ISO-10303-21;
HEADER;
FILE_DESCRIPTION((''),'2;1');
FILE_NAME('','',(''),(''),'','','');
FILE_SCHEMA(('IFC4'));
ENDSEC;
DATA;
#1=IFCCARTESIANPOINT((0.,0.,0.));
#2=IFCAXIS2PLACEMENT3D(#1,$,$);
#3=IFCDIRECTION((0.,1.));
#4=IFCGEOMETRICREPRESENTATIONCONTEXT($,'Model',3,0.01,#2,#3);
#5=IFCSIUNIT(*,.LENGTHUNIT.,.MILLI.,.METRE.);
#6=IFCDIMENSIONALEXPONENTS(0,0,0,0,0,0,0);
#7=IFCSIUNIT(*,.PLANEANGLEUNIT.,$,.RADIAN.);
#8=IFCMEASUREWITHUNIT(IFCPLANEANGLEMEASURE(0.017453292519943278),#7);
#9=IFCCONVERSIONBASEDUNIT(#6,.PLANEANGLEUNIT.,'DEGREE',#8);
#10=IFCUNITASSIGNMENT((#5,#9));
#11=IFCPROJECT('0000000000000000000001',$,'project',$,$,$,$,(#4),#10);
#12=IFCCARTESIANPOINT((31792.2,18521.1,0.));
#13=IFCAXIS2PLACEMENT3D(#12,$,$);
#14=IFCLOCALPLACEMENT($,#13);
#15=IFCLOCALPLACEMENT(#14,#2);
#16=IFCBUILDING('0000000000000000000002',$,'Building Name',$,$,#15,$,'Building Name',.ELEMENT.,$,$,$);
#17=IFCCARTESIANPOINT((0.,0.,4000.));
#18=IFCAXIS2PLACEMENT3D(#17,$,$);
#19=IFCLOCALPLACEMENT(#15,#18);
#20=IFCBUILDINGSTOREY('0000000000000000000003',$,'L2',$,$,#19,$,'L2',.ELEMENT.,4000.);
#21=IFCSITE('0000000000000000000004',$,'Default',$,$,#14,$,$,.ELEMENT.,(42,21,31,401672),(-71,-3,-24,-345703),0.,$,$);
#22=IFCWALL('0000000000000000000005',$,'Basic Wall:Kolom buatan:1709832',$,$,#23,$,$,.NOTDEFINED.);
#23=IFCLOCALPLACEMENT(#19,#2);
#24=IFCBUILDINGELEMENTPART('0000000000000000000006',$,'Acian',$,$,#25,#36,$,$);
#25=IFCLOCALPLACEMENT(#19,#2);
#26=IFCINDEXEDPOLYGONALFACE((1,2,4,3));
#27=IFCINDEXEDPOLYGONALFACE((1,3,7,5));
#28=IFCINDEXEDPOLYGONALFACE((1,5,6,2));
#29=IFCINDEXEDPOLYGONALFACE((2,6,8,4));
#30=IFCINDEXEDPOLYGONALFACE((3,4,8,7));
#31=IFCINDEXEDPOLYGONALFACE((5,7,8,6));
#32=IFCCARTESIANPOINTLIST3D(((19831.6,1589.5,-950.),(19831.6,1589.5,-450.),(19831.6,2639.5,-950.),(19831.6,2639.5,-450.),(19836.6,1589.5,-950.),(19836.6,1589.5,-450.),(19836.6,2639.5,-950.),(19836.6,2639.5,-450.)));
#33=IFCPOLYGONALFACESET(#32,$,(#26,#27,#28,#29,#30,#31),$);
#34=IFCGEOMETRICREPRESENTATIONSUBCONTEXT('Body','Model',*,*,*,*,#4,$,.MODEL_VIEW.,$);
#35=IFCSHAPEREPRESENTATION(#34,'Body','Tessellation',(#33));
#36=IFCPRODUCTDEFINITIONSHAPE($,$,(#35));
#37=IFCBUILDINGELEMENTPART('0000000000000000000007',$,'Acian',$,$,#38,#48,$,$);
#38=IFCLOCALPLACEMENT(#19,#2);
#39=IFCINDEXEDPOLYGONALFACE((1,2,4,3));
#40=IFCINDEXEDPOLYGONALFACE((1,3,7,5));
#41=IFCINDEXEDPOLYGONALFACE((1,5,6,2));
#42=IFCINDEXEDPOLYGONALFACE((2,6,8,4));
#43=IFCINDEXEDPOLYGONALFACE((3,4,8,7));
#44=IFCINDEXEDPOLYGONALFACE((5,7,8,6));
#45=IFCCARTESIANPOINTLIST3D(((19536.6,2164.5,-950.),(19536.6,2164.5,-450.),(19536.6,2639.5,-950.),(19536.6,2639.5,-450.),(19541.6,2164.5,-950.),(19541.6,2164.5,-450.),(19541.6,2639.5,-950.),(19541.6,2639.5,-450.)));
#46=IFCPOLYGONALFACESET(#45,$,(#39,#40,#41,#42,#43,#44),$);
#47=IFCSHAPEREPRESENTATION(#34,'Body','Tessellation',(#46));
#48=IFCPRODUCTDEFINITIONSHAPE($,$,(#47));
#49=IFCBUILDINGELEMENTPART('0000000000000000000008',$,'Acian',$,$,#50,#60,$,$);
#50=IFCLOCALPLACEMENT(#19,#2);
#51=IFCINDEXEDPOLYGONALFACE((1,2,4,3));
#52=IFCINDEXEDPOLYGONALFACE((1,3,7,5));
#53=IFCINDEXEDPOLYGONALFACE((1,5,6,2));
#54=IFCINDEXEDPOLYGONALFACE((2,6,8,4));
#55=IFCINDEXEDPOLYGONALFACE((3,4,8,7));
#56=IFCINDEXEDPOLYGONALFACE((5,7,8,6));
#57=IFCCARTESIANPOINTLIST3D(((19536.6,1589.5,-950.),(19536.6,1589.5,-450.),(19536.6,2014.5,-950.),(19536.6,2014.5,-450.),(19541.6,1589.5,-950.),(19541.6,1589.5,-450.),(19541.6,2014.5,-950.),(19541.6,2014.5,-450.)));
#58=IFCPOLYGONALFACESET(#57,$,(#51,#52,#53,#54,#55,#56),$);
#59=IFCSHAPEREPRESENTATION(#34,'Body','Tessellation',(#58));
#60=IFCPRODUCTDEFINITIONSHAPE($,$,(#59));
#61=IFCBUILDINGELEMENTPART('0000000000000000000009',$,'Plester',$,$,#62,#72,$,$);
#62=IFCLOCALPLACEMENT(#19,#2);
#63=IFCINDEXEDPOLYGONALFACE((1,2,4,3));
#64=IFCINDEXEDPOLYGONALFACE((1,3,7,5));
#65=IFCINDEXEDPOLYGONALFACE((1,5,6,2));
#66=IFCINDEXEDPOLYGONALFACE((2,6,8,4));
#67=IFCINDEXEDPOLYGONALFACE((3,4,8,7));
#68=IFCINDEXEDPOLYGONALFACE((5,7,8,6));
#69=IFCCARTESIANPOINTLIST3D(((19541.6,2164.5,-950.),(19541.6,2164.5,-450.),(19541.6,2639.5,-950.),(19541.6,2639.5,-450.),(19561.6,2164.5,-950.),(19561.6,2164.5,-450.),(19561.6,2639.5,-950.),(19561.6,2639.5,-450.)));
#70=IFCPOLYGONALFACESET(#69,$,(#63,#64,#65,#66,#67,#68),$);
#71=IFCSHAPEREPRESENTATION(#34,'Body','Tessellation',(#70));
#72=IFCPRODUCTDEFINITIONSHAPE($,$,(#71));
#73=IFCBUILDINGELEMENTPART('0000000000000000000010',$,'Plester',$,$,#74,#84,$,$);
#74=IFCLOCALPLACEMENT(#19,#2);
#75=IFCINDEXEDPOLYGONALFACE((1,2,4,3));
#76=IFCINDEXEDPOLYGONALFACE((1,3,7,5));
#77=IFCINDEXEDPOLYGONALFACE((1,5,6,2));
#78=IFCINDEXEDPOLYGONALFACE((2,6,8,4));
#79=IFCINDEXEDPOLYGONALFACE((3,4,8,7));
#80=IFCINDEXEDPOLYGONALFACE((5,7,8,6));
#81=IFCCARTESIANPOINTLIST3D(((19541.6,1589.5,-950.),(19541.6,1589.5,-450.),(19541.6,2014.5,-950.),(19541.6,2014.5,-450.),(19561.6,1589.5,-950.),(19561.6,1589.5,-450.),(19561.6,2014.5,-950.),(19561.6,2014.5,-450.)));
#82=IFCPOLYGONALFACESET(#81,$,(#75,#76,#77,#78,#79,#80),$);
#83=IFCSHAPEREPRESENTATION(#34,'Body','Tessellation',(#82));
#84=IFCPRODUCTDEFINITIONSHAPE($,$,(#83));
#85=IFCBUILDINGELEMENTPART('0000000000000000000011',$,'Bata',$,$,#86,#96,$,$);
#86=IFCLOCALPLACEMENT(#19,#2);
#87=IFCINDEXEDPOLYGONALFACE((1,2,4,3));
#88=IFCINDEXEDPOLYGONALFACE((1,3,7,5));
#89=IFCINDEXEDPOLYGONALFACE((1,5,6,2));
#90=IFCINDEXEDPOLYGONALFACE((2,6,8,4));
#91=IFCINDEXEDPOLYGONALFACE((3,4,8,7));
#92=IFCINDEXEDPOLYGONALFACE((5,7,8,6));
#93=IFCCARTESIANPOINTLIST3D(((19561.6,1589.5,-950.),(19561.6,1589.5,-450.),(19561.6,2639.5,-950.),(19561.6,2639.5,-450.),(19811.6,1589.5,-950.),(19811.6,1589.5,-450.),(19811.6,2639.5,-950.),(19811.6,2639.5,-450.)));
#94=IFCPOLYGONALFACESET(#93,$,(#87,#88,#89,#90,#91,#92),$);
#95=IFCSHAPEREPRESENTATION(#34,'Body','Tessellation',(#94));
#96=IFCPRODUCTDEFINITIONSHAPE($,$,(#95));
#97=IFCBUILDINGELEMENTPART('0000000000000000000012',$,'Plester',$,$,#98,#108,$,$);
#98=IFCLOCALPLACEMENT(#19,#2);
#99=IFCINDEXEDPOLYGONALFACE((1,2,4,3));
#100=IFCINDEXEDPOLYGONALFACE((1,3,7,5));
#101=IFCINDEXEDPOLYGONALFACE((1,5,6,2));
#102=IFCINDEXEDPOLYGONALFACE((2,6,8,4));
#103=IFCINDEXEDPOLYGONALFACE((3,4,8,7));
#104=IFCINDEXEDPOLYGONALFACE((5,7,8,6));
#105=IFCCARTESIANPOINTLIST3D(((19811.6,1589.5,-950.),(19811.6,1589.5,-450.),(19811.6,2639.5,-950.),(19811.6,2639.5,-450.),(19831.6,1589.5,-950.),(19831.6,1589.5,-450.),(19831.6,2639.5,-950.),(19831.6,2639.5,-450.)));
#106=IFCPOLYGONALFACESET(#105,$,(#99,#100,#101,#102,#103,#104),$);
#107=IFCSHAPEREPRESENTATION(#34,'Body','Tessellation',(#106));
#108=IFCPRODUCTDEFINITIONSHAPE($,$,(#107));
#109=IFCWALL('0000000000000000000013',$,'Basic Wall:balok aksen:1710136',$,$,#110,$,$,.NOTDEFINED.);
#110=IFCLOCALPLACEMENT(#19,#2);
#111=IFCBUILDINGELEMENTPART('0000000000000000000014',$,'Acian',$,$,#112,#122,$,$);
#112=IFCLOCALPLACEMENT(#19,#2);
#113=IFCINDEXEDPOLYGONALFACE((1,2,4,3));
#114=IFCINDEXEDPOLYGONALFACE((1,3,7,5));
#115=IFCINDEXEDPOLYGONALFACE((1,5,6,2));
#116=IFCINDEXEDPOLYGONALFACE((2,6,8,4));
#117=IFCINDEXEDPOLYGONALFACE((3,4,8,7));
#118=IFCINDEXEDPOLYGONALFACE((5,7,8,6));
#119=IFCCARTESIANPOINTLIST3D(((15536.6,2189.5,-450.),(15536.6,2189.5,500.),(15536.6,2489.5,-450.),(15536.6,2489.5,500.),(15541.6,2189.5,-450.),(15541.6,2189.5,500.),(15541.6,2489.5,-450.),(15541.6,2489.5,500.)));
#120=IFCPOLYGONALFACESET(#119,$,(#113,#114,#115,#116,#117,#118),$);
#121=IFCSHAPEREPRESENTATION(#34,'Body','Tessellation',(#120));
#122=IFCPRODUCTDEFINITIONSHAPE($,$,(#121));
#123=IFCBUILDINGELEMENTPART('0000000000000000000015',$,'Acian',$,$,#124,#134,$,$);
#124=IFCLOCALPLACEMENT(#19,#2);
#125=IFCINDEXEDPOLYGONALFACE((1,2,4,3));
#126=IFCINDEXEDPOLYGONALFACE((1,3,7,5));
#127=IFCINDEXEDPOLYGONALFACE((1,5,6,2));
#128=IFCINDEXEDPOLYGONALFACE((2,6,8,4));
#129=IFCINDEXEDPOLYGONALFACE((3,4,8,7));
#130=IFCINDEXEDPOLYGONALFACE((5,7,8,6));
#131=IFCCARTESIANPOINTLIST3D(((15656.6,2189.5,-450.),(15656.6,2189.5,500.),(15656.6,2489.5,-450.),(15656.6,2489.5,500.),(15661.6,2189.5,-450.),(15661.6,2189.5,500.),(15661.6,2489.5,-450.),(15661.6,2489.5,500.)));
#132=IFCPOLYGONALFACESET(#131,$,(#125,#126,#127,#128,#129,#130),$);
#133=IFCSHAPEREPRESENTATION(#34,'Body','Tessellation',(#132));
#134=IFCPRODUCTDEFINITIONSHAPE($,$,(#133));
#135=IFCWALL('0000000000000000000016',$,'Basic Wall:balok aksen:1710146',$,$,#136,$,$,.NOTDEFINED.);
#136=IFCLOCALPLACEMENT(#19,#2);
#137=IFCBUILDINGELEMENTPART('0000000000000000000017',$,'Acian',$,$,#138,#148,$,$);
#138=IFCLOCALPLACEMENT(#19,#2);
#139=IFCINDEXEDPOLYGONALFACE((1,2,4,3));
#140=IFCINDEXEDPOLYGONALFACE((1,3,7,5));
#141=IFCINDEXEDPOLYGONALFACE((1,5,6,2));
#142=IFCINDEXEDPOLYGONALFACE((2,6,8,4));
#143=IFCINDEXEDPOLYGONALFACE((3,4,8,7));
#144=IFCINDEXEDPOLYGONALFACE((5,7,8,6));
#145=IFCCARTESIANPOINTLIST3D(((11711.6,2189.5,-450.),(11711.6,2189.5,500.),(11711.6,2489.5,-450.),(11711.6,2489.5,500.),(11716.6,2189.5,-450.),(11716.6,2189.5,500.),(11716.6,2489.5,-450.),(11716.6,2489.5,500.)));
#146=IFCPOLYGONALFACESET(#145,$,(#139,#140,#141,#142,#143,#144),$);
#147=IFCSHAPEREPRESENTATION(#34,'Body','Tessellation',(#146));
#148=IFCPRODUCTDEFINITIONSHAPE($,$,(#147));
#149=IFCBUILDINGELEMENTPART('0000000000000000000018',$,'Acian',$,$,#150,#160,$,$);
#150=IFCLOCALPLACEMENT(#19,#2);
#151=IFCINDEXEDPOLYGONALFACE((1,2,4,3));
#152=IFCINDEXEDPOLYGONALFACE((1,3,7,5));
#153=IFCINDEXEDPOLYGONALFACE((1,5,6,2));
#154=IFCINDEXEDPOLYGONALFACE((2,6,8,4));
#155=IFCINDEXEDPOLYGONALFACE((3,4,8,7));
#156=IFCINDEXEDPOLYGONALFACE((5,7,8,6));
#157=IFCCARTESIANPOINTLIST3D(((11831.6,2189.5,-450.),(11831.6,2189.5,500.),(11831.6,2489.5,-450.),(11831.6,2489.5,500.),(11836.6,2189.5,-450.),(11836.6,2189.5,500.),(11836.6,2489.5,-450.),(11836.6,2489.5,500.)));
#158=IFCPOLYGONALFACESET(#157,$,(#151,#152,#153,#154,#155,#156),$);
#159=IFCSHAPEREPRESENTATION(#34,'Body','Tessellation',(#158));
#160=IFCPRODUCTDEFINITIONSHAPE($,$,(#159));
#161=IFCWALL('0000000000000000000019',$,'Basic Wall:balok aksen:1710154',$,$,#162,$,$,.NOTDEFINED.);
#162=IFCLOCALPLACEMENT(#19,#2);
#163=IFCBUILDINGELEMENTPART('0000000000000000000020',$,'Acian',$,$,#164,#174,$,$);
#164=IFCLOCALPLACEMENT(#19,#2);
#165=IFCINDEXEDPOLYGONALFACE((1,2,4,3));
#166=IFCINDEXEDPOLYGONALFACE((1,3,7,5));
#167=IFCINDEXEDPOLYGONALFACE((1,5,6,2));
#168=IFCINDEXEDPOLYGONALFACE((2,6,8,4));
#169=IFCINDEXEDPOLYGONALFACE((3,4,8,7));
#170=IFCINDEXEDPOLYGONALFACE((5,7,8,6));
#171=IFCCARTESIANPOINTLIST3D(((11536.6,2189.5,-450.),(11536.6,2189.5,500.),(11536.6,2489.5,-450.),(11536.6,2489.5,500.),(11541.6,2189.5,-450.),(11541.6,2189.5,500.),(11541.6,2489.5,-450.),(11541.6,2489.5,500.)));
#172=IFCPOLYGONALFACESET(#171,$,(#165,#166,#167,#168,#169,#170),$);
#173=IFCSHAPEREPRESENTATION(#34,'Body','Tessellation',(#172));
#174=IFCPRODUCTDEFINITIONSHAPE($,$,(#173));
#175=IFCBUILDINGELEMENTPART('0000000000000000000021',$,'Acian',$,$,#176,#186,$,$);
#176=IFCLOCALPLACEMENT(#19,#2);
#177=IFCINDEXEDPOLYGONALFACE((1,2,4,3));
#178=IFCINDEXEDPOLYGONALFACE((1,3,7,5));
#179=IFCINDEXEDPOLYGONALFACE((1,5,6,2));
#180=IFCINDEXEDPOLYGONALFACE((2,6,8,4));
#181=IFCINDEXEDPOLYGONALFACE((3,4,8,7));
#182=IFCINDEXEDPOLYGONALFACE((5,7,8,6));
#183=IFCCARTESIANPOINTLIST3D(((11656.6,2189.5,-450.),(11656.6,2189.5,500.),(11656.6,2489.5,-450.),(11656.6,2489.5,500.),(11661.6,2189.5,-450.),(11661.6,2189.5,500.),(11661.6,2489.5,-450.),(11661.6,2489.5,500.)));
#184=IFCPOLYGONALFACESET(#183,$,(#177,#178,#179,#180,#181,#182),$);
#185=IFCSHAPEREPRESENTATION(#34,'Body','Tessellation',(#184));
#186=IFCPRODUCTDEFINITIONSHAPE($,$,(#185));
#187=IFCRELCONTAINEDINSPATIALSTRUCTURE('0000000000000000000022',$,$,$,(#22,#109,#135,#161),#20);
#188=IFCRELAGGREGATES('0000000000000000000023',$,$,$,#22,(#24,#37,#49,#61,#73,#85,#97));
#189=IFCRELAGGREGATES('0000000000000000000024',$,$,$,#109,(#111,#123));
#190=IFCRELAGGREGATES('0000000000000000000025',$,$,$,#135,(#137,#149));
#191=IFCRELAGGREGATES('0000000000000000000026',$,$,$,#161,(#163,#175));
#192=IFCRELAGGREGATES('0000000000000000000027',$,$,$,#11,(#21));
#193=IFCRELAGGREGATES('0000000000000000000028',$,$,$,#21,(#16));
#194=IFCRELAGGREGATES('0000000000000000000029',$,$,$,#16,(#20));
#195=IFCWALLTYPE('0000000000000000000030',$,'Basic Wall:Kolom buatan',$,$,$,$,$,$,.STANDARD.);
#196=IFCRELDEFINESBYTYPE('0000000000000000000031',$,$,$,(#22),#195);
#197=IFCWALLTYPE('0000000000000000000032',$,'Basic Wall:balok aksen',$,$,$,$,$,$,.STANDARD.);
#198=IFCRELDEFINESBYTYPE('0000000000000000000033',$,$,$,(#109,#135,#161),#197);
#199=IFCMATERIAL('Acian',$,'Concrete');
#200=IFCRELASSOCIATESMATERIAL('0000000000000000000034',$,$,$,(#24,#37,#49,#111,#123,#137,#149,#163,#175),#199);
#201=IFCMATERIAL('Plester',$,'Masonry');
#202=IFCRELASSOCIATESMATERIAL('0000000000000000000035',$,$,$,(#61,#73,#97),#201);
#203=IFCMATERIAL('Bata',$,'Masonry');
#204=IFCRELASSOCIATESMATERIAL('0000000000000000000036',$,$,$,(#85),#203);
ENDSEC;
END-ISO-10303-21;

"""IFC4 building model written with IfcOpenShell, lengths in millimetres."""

from ifc_helpers import new_model, entity, si_unit, converted_unit, direction, frame, origin, place, context, subcontext, project, spatial, indexed_curve, outline, extrude, material, type_object, element, aggregate, save


model = new_model("IFC4")

# Units and contexts
model_context = context("Model", 3, precision=0.01, world=origin(), true_north=direction((0.0, 1.0)))
body_context = subcontext(model_context, "Body", "Model", "MODEL_VIEW")
ifc_project = project(units=[si_unit("LENGTHUNIT", "METRE", prefix="MILLI"), converted_unit("PLANEANGLEUNIT", "DEGREE", entity("IfcPlaneAngleMeasure", 0.017453292519943278), si_unit("PLANEANGLEUNIT", "RADIAN"), dimensions=[0, 0, 0, 0, 0, 0, 0])], contexts=[model_context])

# Site, building, storey
site_placement = place(None, frame((31792.2, 18521.1, 0.0)))
site = spatial("IfcSite", under=ifc_project, at=site_placement, Name="Default", CompositionType="ELEMENT", RefLatitude=(42, 21, 31, 401672), RefLongitude=(-71, -3, -24, -345703), RefElevation=0.0)
building_placement = place(site_placement, origin())
building = spatial("IfcBuilding", under=site, at=building_placement, Name="Building Name", LongName="Building Name", CompositionType="ELEMENT")
storey_placement = place(building_placement, frame((0.0, 0.0, 4000.0)))
storey = spatial("IfcBuildingStorey", under=building, at=storey_placement, Name="L2", LongName="L2", CompositionType="ELEMENT", Elevation=4000.0)

# Shared definitions
ifc_material_1 = material(Name="Acian", Category="Concrete")
ifc_material_2 = material(Name="Plester", Category="Masonry")
ifc_material_3 = material(Name="Bata", Category="Masonry")

# Walls, building element parts
wall_type_1 = type_object("IfcWallType", Name="Basic Wall:Kolom buatan", PredefinedType="STANDARD")
wall_1_placement = place(storey_placement, frame((19686.6, 1589.5, -950.0), z_axis=(0.0, 0.0, 1.0), x_axis=(0.0, 1.0, 0.0)))
wall_1 = element("IfcWall", 1, at=wall_1_placement, inside=storey, type_object=wall_type_1, Name="Basic Wall:Kolom buatan:1709832", PredefinedType="NOTDEFINED")
building_element_part_1_placement = place(wall_1_placement, origin())
building_element_part_1 = element("IfcBuildingElementPart", 2, at=building_element_part_1_placement, material=ifc_material_1, Name="Acian", context=body_context, shape_type="SweptSolid", body=[
    extrude(outline(indexed_curve([(-525.0, -2.5), (525.0, -2.5), (525.0, 2.5), (-525.0, 2.5), (-525.0, -2.5)], self_intersect=False)), frame((525.0, -147.5, 0.0), z_axis=(0.0, 0.0, 1.0), x_axis=(-1.0, 0.0, 0.0)), (0.0, 0.0, 1.0), 500.0),
])
building_element_part_2_placement = place(wall_1_placement, origin())
building_element_part_2 = element("IfcBuildingElementPart", 3, at=building_element_part_2_placement, material=ifc_material_1, Name="Acian", context=body_context, shape_type="SweptSolid", body=[
    extrude(outline(indexed_curve([(-237.5, -2.5), (237.5, -2.5), (237.5, 2.5), (-237.5, 2.5), (-237.5, -2.5)], self_intersect=False)), frame((812.5, 147.5, 0.0), z_axis=(0.0, 0.0, 1.0), x_axis=(-1.0, 0.0, 0.0)), (0.0, 0.0, 1.0), 500.0),
])
building_element_part_3_placement = place(wall_1_placement, origin())
building_element_part_3 = element("IfcBuildingElementPart", 4, at=building_element_part_3_placement, material=ifc_material_1, Name="Acian", context=body_context, shape_type="SweptSolid", body=[
    extrude(outline(indexed_curve([(-212.5, -2.5), (212.5, -2.5), (212.5, 2.5), (-212.5, 2.5), (-212.5, -2.5)], self_intersect=False)), frame((212.5, 147.5, 0.0), z_axis=(0.0, 0.0, 1.0), x_axis=(-1.0, 0.0, 0.0)), (0.0, 0.0, 1.0), 500.0),
])
building_element_part_4_placement = place(wall_1_placement, origin())
building_element_part_4 = element("IfcBuildingElementPart", 5, at=building_element_part_4_placement, material=ifc_material_2, Name="Plester", context=body_context, shape_type="SweptSolid", body=[
    extrude(outline(indexed_curve([(-237.5, -10.0), (237.5, -10.0), (237.5, 10.0), (-237.5, 10.0), (-237.5, -10.0)], self_intersect=False)), frame((812.5, 135.0, 0.0), z_axis=(0.0, 0.0, 1.0), x_axis=(-1.0, 0.0, 0.0)), (0.0, 0.0, 1.0), 500.0),
])
building_element_part_5_placement = place(wall_1_placement, origin())
building_element_part_5 = element("IfcBuildingElementPart", 6, at=building_element_part_5_placement, material=ifc_material_2, Name="Plester", context=body_context, shape_type="SweptSolid", body=[
    extrude(outline(indexed_curve([(-212.5, -10.0), (212.5, -10.0), (212.5, 10.0), (-212.5, 10.0), (-212.5, -10.0)], self_intersect=False)), frame((212.5, 135.0, 0.0), z_axis=(0.0, 0.0, 1.0), x_axis=(-1.0, 0.0, 0.0)), (0.0, 0.0, 1.0), 500.0),
])
building_element_part_6_placement = place(wall_1_placement, origin())
building_element_part_6 = element("IfcBuildingElementPart", 7, at=building_element_part_6_placement, material=ifc_material_3, Name="Bata", context=body_context, shape_type="SweptSolid", body=[
    extrude(outline(indexed_curve([(-525.0, -125.0), (525.0, -125.0), (525.0, 125.0), (-525.0, 125.0), (-525.0, -125.0)], self_intersect=False)), frame((525.0, 0.0, 0.0), z_axis=(0.0, 0.0, 1.0), x_axis=(-1.0, 0.0, 0.0)), (0.0, 0.0, 1.0), 500.0),
])
building_element_part_7_placement = place(wall_1_placement, origin())
building_element_part_7 = element("IfcBuildingElementPart", 8, at=building_element_part_7_placement, material=ifc_material_2, Name="Plester", context=body_context, shape_type="SweptSolid", body=[
    extrude(outline(indexed_curve([(-525.0, -10.0), (525.0, -10.0), (525.0, 10.0), (-525.0, 10.0), (-525.0, -10.0)], self_intersect=False)), frame((525.0, -135.0, 0.0), z_axis=(0.0, 0.0, 1.0), x_axis=(-1.0, 0.0, 0.0)), (0.0, 0.0, 1.0), 500.0),
])
aggregate(wall_1, [building_element_part_1, building_element_part_2, building_element_part_3, building_element_part_4, building_element_part_5, building_element_part_6, building_element_part_7])
wall_type_2 = type_object("IfcWallType", Name="Basic Wall:balok aksen", PredefinedType="STANDARD")
wall_2_placement = place(storey_placement, frame((15599.1, 2489.5, -450.0), z_axis=(0.0, 0.0, 1.0), x_axis=(0.0, -1.0, 0.0)))
wall_2 = element("IfcWall", 9, at=wall_2_placement, inside=storey, type_object=wall_type_2, Name="Basic Wall:balok aksen:1710136", PredefinedType="NOTDEFINED")
building_element_part_8_placement = place(wall_2_placement, origin())
building_element_part_8 = element("IfcBuildingElementPart", 10, at=building_element_part_8_placement, material=ifc_material_1, Name="Acian", context=body_context, shape_type="SweptSolid", body=[
    extrude(outline(indexed_curve([(-150.0, -2.5), (150.0, -2.5), (150.0, 2.5), (-150.0, 2.5), (-150.0, -2.5)], self_intersect=False)), frame((150.0, -60.0, 0.0)), (0.0, 0.0, 1.0), 950.0),
])
building_element_part_9_placement = place(wall_2_placement, origin())
building_element_part_9 = element("IfcBuildingElementPart", 11, at=building_element_part_9_placement, material=ifc_material_1, Name="Acian", context=body_context, shape_type="SweptSolid", body=[
    extrude(outline(indexed_curve([(-150.0, -2.5), (150.0, -2.5), (150.0, 2.5), (-150.0, 2.5), (-150.0, -2.5)], self_intersect=False)), frame((150.0, 60.0, 0.0)), (0.0, 0.0, 1.0), 950.0),
])
aggregate(wall_2, [building_element_part_8, building_element_part_9])
wall_3_placement = place(storey_placement, frame((11774.1, 2489.5, -450.0), z_axis=(0.0, 0.0, 1.0), x_axis=(0.0, -1.0, 0.0)))
wall_3 = element("IfcWall", 12, at=wall_3_placement, inside=storey, type_object=wall_type_2, Name="Basic Wall:balok aksen:1710146", PredefinedType="NOTDEFINED")
building_element_part_10_placement = place(wall_3_placement, origin())
building_element_part_10 = element("IfcBuildingElementPart", 13, at=building_element_part_10_placement, material=ifc_material_1, Name="Acian", context=body_context, shape_type="SweptSolid", body=[
    extrude(outline(indexed_curve([(-150.0, -2.5), (150.0, -2.5), (150.0, 2.5), (-150.0, 2.5), (-150.0, -2.5)], self_intersect=False)), frame((150.0, -60.0, 0.0)), (0.0, 0.0, 1.0), 950.0),
])
building_element_part_11_placement = place(wall_3_placement, origin())
building_element_part_11 = element("IfcBuildingElementPart", 14, at=building_element_part_11_placement, material=ifc_material_1, Name="Acian", context=body_context, shape_type="SweptSolid", body=[
    extrude(outline(indexed_curve([(-150.0, -2.5), (150.0, -2.5), (150.0, 2.5), (-150.0, 2.5), (-150.0, -2.5)], self_intersect=False)), frame((150.0, 60.0, 0.0)), (0.0, 0.0, 1.0), 950.0),
])
aggregate(wall_3, [building_element_part_10, building_element_part_11])
wall_4_placement = place(storey_placement, frame((11599.1, 2489.5, -450.0), z_axis=(0.0, 0.0, 1.0), x_axis=(0.0, -1.0, 0.0)))
wall_4 = element("IfcWall", 15, at=wall_4_placement, inside=storey, type_object=wall_type_2, Name="Basic Wall:balok aksen:1710154", PredefinedType="NOTDEFINED")
building_element_part_12_placement = place(wall_4_placement, origin())
building_element_part_12 = element("IfcBuildingElementPart", 16, at=building_element_part_12_placement, material=ifc_material_1, Name="Acian", context=body_context, shape_type="SweptSolid", body=[
    extrude(outline(indexed_curve([(-150.0, -2.5), (150.0, -2.5), (150.0, 2.5), (-150.0, 2.5), (-150.0, -2.5)], self_intersect=False)), frame((150.0, -60.0, 0.0)), (0.0, 0.0, 1.0), 950.0),
])
building_element_part_13_placement = place(wall_4_placement, origin())
building_element_part_13 = element("IfcBuildingElementPart", 17, at=building_element_part_13_placement, material=ifc_material_1, Name="Acian", context=body_context, shape_type="SweptSolid", body=[
    extrude(outline(indexed_curve([(-150.0, -2.5), (150.0, -2.5), (150.0, 2.5), (-150.0, 2.5), (-150.0, -2.5)], self_intersect=False)), frame((150.0, 60.0, 0.0)), (0.0, 0.0, 1.0), 950.0),
])
aggregate(wall_4, [building_element_part_12, building_element_part_13])

save(model, "model.ifc")
